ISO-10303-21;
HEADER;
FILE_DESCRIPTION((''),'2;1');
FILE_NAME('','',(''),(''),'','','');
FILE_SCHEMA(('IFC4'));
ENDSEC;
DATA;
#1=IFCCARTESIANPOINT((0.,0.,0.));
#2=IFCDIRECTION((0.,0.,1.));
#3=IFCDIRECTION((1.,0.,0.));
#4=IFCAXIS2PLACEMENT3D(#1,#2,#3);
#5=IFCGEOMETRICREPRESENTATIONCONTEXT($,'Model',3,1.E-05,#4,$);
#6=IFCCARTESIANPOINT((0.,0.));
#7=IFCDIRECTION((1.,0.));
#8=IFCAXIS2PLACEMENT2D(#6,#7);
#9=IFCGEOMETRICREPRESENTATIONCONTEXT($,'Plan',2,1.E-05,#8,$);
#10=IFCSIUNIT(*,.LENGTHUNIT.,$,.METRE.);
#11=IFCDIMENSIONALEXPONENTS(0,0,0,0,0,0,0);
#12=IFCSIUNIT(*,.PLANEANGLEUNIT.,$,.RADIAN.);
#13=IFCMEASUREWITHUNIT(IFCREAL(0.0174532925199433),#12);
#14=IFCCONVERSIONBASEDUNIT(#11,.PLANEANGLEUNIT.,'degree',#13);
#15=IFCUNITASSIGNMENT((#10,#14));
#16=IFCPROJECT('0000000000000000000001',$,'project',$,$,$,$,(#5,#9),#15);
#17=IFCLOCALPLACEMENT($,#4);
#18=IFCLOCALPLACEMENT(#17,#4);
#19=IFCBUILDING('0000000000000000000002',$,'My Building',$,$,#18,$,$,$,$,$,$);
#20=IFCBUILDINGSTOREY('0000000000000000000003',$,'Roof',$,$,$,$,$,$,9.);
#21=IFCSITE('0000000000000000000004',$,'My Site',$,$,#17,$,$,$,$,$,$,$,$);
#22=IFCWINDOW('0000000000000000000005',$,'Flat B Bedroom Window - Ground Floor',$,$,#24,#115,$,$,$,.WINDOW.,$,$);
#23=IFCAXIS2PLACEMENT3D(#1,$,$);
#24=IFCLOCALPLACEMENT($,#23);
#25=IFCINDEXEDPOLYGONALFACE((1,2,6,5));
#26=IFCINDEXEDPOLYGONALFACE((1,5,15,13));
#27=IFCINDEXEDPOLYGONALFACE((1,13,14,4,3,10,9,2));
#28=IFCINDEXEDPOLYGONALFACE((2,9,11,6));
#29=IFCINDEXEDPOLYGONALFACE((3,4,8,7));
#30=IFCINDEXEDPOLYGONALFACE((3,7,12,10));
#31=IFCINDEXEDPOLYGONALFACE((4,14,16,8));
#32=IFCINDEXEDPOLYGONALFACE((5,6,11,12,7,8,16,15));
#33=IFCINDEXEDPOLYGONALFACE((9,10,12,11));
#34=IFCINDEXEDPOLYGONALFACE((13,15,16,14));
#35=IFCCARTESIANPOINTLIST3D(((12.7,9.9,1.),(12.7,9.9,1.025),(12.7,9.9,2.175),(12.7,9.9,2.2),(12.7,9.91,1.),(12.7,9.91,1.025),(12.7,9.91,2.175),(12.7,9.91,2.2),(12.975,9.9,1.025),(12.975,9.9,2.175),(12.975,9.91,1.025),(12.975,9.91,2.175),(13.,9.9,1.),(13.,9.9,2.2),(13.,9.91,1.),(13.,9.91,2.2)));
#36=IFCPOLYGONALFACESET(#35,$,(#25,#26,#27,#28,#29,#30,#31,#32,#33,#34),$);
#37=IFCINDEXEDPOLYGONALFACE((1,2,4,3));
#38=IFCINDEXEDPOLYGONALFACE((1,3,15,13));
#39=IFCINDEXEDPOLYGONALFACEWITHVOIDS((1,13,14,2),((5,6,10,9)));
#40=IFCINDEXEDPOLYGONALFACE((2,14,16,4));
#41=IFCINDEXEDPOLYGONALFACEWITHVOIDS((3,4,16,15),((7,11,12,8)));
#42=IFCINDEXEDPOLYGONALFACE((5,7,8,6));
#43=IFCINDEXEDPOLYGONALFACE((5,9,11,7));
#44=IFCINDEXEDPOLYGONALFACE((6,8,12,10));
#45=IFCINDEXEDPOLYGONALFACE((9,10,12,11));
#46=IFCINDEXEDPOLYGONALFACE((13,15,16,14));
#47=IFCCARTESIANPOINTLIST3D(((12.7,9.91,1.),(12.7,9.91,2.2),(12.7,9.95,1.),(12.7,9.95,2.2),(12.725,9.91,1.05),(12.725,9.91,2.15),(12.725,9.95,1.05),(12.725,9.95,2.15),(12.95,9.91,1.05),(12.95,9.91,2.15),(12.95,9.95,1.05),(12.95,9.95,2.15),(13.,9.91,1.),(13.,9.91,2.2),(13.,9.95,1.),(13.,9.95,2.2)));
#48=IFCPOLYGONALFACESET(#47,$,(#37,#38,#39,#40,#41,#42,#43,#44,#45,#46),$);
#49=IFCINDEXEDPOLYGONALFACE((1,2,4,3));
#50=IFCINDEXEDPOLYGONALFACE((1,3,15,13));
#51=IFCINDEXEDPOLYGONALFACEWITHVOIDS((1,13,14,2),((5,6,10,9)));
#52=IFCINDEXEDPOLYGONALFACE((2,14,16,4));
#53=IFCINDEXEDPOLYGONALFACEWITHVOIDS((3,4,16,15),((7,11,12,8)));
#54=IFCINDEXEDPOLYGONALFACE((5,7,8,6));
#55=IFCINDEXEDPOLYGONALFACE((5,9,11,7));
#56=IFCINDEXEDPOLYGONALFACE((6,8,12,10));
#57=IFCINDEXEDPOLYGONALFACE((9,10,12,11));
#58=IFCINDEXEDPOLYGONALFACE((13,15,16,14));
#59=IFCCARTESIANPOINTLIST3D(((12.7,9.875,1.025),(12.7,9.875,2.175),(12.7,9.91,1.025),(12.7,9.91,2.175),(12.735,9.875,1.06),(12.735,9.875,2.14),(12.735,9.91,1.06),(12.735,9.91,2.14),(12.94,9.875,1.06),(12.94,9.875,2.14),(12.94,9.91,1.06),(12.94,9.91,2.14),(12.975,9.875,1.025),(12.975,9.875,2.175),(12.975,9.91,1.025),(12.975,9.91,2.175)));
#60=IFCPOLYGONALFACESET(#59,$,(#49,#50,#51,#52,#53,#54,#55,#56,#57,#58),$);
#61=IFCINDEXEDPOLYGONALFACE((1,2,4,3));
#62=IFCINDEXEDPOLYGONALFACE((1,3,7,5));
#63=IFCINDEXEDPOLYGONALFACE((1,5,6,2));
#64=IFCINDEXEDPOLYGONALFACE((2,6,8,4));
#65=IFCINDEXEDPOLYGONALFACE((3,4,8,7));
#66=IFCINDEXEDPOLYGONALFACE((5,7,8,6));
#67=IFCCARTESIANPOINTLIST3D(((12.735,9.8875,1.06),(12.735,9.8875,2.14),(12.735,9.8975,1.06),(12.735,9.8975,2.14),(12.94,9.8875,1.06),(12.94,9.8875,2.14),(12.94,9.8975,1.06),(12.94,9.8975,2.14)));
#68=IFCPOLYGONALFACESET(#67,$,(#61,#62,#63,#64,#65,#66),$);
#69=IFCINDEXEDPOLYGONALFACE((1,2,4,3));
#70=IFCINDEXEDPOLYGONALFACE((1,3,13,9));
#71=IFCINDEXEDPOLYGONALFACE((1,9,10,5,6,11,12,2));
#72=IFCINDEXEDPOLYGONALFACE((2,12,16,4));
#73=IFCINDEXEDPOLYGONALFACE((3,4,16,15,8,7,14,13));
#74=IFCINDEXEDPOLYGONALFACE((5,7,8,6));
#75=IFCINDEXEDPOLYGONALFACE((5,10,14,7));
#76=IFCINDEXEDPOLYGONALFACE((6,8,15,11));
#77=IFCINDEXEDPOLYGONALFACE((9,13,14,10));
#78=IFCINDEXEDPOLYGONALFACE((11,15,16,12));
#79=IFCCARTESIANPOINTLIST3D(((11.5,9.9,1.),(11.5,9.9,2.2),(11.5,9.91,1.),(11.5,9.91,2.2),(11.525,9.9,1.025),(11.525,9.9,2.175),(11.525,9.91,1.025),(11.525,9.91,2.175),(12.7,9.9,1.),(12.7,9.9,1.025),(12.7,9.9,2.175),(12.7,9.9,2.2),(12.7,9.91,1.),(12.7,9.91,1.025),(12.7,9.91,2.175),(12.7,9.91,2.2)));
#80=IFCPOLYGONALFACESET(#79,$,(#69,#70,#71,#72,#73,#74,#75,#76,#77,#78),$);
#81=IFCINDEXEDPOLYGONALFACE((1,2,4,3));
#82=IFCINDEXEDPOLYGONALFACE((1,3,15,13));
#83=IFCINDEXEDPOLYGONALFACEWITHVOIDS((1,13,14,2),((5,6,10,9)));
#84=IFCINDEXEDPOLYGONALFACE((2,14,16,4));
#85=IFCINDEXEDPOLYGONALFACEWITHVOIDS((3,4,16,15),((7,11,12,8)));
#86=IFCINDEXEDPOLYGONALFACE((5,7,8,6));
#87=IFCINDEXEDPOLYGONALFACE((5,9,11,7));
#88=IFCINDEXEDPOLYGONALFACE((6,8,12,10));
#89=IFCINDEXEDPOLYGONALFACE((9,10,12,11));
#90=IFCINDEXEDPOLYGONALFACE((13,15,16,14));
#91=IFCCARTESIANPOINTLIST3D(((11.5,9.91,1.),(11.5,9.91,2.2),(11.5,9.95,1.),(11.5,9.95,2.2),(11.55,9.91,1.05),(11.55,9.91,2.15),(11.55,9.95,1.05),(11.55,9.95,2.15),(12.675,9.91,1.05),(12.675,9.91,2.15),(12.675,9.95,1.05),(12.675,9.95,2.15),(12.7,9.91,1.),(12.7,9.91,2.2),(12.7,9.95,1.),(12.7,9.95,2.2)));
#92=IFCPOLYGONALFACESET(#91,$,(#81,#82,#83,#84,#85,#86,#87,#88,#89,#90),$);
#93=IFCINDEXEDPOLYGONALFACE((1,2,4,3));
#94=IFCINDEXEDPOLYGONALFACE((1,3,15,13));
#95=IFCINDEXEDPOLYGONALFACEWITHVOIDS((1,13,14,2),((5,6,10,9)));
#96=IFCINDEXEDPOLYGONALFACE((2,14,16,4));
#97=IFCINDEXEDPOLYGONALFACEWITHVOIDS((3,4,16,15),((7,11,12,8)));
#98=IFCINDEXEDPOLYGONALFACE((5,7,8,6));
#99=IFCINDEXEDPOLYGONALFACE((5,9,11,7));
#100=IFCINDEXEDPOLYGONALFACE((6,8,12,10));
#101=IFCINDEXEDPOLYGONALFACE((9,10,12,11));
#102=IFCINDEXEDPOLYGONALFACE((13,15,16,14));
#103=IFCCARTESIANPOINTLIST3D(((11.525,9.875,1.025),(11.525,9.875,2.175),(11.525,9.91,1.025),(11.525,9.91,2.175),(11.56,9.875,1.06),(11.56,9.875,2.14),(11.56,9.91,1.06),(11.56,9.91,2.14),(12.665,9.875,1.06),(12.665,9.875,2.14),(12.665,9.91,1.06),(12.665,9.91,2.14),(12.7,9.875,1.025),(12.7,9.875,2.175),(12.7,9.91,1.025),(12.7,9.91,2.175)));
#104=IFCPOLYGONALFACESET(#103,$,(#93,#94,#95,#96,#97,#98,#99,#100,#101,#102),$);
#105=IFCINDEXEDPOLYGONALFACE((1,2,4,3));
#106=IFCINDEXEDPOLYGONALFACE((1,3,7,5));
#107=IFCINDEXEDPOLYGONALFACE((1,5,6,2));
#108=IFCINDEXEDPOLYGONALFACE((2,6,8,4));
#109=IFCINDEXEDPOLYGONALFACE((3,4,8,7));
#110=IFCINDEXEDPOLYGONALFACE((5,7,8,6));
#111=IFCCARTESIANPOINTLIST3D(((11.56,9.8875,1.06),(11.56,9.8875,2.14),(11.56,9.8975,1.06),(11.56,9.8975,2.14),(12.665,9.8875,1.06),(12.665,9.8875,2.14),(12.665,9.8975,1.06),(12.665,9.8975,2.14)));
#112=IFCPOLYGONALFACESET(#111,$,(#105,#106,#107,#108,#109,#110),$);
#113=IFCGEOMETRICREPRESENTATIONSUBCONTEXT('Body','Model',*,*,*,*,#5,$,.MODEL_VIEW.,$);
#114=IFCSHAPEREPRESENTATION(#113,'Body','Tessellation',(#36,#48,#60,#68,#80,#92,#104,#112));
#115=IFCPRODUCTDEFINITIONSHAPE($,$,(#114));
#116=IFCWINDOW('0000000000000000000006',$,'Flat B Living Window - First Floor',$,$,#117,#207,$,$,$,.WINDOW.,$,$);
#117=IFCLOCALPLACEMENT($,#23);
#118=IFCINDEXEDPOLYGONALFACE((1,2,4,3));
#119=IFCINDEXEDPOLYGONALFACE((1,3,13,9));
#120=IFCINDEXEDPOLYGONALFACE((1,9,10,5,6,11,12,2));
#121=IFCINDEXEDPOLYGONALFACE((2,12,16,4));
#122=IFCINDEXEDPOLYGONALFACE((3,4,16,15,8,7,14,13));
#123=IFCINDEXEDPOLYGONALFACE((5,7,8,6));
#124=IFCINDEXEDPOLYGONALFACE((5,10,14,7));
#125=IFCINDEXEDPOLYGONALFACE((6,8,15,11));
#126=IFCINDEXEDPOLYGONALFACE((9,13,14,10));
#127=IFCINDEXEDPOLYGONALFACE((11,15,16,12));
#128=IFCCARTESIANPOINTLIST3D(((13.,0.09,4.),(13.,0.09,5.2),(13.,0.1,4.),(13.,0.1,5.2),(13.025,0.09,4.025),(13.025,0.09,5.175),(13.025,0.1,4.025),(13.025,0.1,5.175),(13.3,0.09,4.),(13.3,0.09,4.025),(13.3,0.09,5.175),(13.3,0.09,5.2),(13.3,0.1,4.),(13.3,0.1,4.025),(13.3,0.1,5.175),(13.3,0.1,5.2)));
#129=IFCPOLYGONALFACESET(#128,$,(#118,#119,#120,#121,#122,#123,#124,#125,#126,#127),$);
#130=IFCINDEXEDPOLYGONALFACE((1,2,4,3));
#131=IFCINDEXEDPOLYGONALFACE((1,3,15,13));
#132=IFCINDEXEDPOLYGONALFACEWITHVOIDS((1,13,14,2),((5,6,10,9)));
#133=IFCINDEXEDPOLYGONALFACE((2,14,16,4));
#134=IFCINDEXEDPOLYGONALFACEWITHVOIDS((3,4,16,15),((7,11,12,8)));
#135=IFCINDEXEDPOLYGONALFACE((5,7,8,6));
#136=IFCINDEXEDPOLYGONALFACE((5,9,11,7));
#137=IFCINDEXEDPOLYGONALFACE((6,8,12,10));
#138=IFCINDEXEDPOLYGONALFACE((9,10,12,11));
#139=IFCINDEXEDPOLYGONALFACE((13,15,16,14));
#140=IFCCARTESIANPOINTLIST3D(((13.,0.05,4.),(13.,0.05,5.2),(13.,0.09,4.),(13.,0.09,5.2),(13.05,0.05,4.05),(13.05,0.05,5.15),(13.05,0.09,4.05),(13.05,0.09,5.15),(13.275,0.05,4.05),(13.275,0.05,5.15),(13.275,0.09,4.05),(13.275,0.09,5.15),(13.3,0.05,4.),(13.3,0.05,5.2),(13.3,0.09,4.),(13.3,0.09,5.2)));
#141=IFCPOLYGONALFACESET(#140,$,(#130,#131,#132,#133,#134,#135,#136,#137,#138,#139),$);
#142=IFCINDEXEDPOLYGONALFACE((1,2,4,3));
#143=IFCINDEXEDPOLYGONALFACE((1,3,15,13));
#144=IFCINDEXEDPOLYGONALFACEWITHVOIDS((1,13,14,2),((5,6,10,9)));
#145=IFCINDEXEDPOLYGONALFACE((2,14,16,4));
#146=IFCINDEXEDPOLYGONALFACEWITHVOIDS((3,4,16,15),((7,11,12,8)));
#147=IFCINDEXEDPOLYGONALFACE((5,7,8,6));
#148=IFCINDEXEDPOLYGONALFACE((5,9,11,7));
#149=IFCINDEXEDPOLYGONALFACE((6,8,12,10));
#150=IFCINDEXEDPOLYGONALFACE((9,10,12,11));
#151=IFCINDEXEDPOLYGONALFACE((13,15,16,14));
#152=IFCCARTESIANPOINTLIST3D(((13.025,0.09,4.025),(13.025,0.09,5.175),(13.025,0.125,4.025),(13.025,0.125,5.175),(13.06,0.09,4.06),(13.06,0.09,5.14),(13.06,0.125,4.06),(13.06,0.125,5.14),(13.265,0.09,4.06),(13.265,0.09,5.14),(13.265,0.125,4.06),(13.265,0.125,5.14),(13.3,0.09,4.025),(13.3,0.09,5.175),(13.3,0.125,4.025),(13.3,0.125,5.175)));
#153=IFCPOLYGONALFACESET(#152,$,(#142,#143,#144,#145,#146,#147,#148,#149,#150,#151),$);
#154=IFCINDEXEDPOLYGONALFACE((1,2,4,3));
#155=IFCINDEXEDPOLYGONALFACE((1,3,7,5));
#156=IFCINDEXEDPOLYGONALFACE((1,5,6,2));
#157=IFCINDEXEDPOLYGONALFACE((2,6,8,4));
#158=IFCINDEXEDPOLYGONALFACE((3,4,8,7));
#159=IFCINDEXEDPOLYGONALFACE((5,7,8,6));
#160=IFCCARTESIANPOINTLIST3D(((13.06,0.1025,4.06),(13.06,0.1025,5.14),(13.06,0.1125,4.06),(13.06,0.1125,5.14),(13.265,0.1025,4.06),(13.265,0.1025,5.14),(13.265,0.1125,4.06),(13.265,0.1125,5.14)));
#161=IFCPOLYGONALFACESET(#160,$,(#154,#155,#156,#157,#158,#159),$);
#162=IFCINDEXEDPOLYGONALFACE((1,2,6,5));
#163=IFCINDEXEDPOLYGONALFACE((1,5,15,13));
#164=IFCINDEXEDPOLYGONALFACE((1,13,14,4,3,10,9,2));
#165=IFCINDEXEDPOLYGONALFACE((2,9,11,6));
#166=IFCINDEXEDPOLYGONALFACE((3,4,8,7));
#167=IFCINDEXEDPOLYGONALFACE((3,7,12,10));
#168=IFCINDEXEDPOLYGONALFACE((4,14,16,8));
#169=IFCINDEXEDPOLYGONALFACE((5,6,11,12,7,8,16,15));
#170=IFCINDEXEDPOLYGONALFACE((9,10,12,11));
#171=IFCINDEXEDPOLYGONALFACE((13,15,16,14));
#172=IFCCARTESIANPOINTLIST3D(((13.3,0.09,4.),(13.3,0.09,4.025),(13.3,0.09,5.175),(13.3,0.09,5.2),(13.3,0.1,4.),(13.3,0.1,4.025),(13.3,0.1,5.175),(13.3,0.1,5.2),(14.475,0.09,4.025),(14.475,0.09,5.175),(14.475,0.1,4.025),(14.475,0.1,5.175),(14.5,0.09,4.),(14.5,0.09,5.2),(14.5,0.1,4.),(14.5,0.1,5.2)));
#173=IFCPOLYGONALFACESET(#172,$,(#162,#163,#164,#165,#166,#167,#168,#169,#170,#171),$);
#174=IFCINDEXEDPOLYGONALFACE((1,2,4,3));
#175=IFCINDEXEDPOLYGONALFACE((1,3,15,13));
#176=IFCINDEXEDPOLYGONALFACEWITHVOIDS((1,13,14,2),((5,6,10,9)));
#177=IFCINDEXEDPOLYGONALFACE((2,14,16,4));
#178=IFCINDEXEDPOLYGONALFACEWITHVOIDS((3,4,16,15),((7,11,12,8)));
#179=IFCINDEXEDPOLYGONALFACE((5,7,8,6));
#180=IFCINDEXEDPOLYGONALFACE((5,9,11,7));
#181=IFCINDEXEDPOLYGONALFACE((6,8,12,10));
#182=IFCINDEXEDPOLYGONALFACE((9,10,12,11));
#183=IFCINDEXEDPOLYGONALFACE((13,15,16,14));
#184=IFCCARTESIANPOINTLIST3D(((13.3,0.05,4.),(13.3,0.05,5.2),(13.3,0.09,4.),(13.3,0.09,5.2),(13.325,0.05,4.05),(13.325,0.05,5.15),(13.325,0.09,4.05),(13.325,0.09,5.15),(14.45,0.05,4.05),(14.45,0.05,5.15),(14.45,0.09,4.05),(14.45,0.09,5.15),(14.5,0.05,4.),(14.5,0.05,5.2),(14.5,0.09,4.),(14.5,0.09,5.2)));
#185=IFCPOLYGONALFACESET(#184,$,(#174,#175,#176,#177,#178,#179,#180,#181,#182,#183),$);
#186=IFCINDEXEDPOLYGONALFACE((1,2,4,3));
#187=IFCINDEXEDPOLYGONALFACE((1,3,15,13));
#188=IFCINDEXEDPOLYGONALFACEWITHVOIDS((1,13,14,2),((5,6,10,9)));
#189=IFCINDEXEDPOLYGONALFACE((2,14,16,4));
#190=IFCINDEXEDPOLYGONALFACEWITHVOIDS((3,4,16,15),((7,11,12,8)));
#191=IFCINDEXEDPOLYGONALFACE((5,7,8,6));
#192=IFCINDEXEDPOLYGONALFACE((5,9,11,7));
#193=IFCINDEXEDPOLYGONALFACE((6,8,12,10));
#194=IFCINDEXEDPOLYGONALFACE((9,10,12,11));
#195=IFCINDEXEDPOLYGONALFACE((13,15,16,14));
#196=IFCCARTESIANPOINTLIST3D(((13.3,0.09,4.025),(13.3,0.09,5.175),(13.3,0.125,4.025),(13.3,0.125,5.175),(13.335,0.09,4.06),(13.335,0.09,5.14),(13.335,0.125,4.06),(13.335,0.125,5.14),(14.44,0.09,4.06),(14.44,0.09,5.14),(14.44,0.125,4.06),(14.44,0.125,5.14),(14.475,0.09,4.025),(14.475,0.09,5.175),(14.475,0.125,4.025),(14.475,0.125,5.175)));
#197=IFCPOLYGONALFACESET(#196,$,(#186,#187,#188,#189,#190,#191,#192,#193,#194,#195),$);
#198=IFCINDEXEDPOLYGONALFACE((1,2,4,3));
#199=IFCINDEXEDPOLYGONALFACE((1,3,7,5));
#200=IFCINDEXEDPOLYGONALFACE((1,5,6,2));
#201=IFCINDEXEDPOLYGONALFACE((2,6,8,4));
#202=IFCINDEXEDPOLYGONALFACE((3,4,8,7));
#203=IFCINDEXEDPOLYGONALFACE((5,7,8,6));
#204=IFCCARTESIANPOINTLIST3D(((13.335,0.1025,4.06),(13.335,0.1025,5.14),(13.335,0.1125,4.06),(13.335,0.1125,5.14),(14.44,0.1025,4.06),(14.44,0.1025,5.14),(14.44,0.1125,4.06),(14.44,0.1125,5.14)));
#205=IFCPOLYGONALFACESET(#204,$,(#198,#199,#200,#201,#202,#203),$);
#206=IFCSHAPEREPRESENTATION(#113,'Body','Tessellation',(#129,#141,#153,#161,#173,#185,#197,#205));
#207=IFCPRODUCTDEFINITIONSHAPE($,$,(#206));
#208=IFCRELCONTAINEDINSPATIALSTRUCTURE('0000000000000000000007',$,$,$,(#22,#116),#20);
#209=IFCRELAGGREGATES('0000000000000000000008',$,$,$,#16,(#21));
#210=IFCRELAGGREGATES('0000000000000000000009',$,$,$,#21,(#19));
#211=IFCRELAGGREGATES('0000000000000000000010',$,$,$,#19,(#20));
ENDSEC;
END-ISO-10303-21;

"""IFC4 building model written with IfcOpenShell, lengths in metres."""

from ifc_helpers import new_model, entity, si_unit, converted_unit, frame, origin_with_axes, origin_2d_with_axis, place, context, subcontext, project, spatial, line, indexed_curve, outline, extrude, element, save


model = new_model("IFC4")

# Units and contexts
model_context = context("Model", 3, precision=1e-05, world=origin_with_axes())
plan_context = context("Plan", 2, precision=1e-05, world=origin_2d_with_axis())
body_context = subcontext(model_context, "Body", "Model", "MODEL_VIEW")
ifc_project = project(units=[si_unit("LENGTHUNIT", "METRE"), converted_unit("PLANEANGLEUNIT", "degree", entity("IfcReal", 0.0174532925199433), si_unit("PLANEANGLEUNIT", "RADIAN"), dimensions=[0, 0, 0, 0, 0, 0, 0])], contexts=[model_context, plan_context])

# Site, building, storey
site_placement = place(None, origin_with_axes())
site = spatial("IfcSite", under=ifc_project, at=site_placement, Name="My Site")
building_placement = place(site_placement, origin_with_axes())
building = spatial("IfcBuilding", under=site, at=building_placement, Name="My Building")
storey = spatial("IfcBuildingStorey", under=building, Name="Roof", Elevation=9.0)

# Windows
window_1_placement = place(None, frame((13.0, 10.0, 1.0), z_axis=(0.0, 0.0, 1.0), x_axis=(-1.0, 0.0, 0.0)))
element("IfcWindow", 1, at=window_1_placement, inside=storey, Name="Flat B Bedroom Window - Ground Floor", PredefinedType="WINDOW", context=body_context, shape_type="SweptSolid", body=[
    extrude(outline(indexed_curve([(0.3, 0.0), (0.0, 0.0), (0.0, 1.2), (0.3, 1.2), (0.3, 1.175), (0.025, 1.175), (0.025, 0.025), (0.3, 0.025)], segments=[line(1, 2, 3, 4, 5, 6, 7, 8, 1)])), frame((0.0, 0.09, 0.0), z_axis=(0.0, -1.0, 0.0), x_axis=(1.0, 0.0, 0.0)), (0.0, 0.0, -1.0), 0.01),
    extrude(outline(indexed_curve([(0.0, 0.0), (0.3, 0.0), (0.3, 1.2), (0.0, 1.2)], segments=[line(1, 2, 3, 4, 1)]), holes=[indexed_curve([(0.05, 0.05), (0.275, 0.05), (0.275, 1.15), (0.05, 1.15)], segments=[line(1, 2, 3, 4, 1)])]), frame((0.0, 0.05, 0.0), z_axis=(0.0, -1.0, 0.0), x_axis=(1.0, 0.0, 0.0)), (0.0, 0.0, -1.0), 0.04),
    extrude(outline(indexed_curve([(0.0, 0.0), (0.275, 0.0), (0.275, 1.15), (0.0, 1.15)], segments=[line(1, 2, 3, 4, 1)]), holes=[indexed_curve([(0.035, 0.035), (0.24, 0.035), (0.24, 1.115), (0.035, 1.115)], segments=[line(1, 2, 3, 4, 1)])]), frame((0.025, 0.09, 0.025), z_axis=(0.0, -1.0, 0.0), x_axis=(1.0, 0.0, 0.0)), (0.0, 0.0, -1.0), 0.035),
    extrude(outline(indexed_curve([(0.035, 0.035), (0.24, 0.035), (0.24, 1.115), (0.035, 1.115)], segments=[line(1, 2, 3, 4, 1)])), frame((0.025, 0.1025, 0.025), z_axis=(0.0, -1.0, 0.0), x_axis=(1.0, 0.0, 0.0)), (0.0, 0.0, -1.0), 0.01),
    extrude(outline(indexed_curve([(0.0, 1.2), (1.2, 1.2), (1.2, 0.0), (0.0, 0.0), (0.0, 0.025), (1.175, 0.025), (1.175, 1.175), (0.0, 1.175)], segments=[line(1, 2, 3, 4, 5, 6, 7, 8, 1)])), frame((0.3, 0.09, 0.0), z_axis=(0.0, -1.0, 0.0), x_axis=(1.0, 0.0, 0.0)), (0.0, 0.0, -1.0), 0.01),
    extrude(outline(indexed_curve([(0.0, 0.0), (1.2, 0.0), (1.2, 1.2), (0.0, 1.2)], segments=[line(1, 2, 3, 4, 1)]), holes=[indexed_curve([(0.025, 0.05), (1.15, 0.05), (1.15, 1.15), (0.025, 1.15)], segments=[line(1, 2, 3, 4, 1)])]), frame((0.3, 0.05, 0.0), z_axis=(0.0, -1.0, 0.0), x_axis=(1.0, 0.0, 0.0)), (0.0, 0.0, -1.0), 0.04),
    extrude(outline(indexed_curve([(0.0, 0.0), (1.175, 0.0), (1.175, 1.15), (0.0, 1.15)], segments=[line(1, 2, 3, 4, 1)]), holes=[indexed_curve([(0.035, 0.035), (1.14, 0.035), (1.14, 1.115), (0.035, 1.115)], segments=[line(1, 2, 3, 4, 1)])]), frame((0.3, 0.09, 0.025), z_axis=(0.0, -1.0, 0.0), x_axis=(1.0, 0.0, 0.0)), (0.0, 0.0, -1.0), 0.035),
    extrude(outline(indexed_curve([(0.035, 0.035), (1.14, 0.035), (1.14, 1.115), (0.035, 1.115)], segments=[line(1, 2, 3, 4, 1)])), frame((0.3, 0.1025, 0.025), z_axis=(0.0, -1.0, 0.0), x_axis=(1.0, 0.0, 0.0)), (0.0, 0.0, -1.0), 0.01),
])
window_2_placement = place(None, frame((13.0, 0.0, 4.0), z_axis=(0.0, 0.0, 1.0), x_axis=(1.0, 0.0, 0.0)))
element("IfcWindow", 2, at=window_2_placement, inside=storey, Name="Flat B Living Window - First Floor", PredefinedType="WINDOW", context=body_context, shape_type="SweptSolid", body=[
    extrude(outline(indexed_curve([(0.3, 0.0), (0.0, 0.0), (0.0, 1.2), (0.3, 1.2), (0.3, 1.175), (0.025, 1.175), (0.025, 0.025), (0.3, 0.025)], segments=[line(1, 2, 3, 4, 5, 6, 7, 8, 1)])), frame((0.0, 0.09, 0.0), z_axis=(0.0, -1.0, 0.0), x_axis=(1.0, 0.0, 0.0)), (0.0, 0.0, -1.0), 0.01),
    extrude(outline(indexed_curve([(0.0, 0.0), (0.3, 0.0), (0.3, 1.2), (0.0, 1.2)], segments=[line(1, 2, 3, 4, 1)]), holes=[indexed_curve([(0.05, 0.05), (0.275, 0.05), (0.275, 1.15), (0.05, 1.15)], segments=[line(1, 2, 3, 4, 1)])]), frame((0.0, 0.05, 0.0), z_axis=(0.0, -1.0, 0.0), x_axis=(1.0, 0.0, 0.0)), (0.0, 0.0, -1.0), 0.04),
    extrude(outline(indexed_curve([(0.0, 0.0), (0.275, 0.0), (0.275, 1.15), (0.0, 1.15)], segments=[line(1, 2, 3, 4, 1)]), holes=[indexed_curve([(0.035, 0.035), (0.24, 0.035), (0.24, 1.115), (0.035, 1.115)], segments=[line(1, 2, 3, 4, 1)])]), frame((0.025, 0.09, 0.025), z_axis=(0.0, -1.0, 0.0), x_axis=(1.0, 0.0, 0.0)), (0.0, 0.0, -1.0), 0.035),
    extrude(outline(indexed_curve([(0.035, 0.035), (0.24, 0.035), (0.24, 1.115), (0.035, 1.115)], segments=[line(1, 2, 3, 4, 1)])), frame((0.025, 0.1025, 0.025), z_axis=(0.0, -1.0, 0.0), x_axis=(1.0, 0.0, 0.0)), (0.0, 0.0, -1.0), 0.01),
    extrude(outline(indexed_curve([(0.0, 1.2), (1.2, 1.2), (1.2, 0.0), (0.0, 0.0), (0.0, 0.025), (1.175, 0.025), (1.175, 1.175), (0.0, 1.175)], segments=[line(1, 2, 3, 4, 5, 6, 7, 8, 1)])), frame((0.3, 0.09, 0.0), z_axis=(0.0, -1.0, 0.0), x_axis=(1.0, 0.0, 0.0)), (0.0, 0.0, -1.0), 0.01),
    extrude(outline(indexed_curve([(0.0, 0.0), (1.2, 0.0), (1.2, 1.2), (0.0, 1.2)], segments=[line(1, 2, 3, 4, 1)]), holes=[indexed_curve([(0.025, 0.05), (1.15, 0.05), (1.15, 1.15), (0.025, 1.15)], segments=[line(1, 2, 3, 4, 1)])]), frame((0.3, 0.05, 0.0), z_axis=(0.0, -1.0, 0.0), x_axis=(1.0, 0.0, 0.0)), (0.0, 0.0, -1.0), 0.04),
    extrude(outline(indexed_curve([(0.0, 0.0), (1.175, 0.0), (1.175, 1.15), (0.0, 1.15)], segments=[line(1, 2, 3, 4, 1)]), holes=[indexed_curve([(0.035, 0.035), (1.14, 0.035), (1.14, 1.115), (0.035, 1.115)], segments=[line(1, 2, 3, 4, 1)])]), frame((0.3, 0.09, 0.025), z_axis=(0.0, -1.0, 0.0), x_axis=(1.0, 0.0, 0.0)), (0.0, 0.0, -1.0), 0.035),
    extrude(outline(indexed_curve([(0.035, 0.035), (1.14, 0.035), (1.14, 1.115), (0.035, 1.115)], segments=[line(1, 2, 3, 4, 1)])), frame((0.3, 0.1025, 0.025), z_axis=(0.0, -1.0, 0.0), x_axis=(1.0, 0.0, 0.0)), (0.0, 0.0, -1.0), 0.01),
])

save(model, "model.ifc")
